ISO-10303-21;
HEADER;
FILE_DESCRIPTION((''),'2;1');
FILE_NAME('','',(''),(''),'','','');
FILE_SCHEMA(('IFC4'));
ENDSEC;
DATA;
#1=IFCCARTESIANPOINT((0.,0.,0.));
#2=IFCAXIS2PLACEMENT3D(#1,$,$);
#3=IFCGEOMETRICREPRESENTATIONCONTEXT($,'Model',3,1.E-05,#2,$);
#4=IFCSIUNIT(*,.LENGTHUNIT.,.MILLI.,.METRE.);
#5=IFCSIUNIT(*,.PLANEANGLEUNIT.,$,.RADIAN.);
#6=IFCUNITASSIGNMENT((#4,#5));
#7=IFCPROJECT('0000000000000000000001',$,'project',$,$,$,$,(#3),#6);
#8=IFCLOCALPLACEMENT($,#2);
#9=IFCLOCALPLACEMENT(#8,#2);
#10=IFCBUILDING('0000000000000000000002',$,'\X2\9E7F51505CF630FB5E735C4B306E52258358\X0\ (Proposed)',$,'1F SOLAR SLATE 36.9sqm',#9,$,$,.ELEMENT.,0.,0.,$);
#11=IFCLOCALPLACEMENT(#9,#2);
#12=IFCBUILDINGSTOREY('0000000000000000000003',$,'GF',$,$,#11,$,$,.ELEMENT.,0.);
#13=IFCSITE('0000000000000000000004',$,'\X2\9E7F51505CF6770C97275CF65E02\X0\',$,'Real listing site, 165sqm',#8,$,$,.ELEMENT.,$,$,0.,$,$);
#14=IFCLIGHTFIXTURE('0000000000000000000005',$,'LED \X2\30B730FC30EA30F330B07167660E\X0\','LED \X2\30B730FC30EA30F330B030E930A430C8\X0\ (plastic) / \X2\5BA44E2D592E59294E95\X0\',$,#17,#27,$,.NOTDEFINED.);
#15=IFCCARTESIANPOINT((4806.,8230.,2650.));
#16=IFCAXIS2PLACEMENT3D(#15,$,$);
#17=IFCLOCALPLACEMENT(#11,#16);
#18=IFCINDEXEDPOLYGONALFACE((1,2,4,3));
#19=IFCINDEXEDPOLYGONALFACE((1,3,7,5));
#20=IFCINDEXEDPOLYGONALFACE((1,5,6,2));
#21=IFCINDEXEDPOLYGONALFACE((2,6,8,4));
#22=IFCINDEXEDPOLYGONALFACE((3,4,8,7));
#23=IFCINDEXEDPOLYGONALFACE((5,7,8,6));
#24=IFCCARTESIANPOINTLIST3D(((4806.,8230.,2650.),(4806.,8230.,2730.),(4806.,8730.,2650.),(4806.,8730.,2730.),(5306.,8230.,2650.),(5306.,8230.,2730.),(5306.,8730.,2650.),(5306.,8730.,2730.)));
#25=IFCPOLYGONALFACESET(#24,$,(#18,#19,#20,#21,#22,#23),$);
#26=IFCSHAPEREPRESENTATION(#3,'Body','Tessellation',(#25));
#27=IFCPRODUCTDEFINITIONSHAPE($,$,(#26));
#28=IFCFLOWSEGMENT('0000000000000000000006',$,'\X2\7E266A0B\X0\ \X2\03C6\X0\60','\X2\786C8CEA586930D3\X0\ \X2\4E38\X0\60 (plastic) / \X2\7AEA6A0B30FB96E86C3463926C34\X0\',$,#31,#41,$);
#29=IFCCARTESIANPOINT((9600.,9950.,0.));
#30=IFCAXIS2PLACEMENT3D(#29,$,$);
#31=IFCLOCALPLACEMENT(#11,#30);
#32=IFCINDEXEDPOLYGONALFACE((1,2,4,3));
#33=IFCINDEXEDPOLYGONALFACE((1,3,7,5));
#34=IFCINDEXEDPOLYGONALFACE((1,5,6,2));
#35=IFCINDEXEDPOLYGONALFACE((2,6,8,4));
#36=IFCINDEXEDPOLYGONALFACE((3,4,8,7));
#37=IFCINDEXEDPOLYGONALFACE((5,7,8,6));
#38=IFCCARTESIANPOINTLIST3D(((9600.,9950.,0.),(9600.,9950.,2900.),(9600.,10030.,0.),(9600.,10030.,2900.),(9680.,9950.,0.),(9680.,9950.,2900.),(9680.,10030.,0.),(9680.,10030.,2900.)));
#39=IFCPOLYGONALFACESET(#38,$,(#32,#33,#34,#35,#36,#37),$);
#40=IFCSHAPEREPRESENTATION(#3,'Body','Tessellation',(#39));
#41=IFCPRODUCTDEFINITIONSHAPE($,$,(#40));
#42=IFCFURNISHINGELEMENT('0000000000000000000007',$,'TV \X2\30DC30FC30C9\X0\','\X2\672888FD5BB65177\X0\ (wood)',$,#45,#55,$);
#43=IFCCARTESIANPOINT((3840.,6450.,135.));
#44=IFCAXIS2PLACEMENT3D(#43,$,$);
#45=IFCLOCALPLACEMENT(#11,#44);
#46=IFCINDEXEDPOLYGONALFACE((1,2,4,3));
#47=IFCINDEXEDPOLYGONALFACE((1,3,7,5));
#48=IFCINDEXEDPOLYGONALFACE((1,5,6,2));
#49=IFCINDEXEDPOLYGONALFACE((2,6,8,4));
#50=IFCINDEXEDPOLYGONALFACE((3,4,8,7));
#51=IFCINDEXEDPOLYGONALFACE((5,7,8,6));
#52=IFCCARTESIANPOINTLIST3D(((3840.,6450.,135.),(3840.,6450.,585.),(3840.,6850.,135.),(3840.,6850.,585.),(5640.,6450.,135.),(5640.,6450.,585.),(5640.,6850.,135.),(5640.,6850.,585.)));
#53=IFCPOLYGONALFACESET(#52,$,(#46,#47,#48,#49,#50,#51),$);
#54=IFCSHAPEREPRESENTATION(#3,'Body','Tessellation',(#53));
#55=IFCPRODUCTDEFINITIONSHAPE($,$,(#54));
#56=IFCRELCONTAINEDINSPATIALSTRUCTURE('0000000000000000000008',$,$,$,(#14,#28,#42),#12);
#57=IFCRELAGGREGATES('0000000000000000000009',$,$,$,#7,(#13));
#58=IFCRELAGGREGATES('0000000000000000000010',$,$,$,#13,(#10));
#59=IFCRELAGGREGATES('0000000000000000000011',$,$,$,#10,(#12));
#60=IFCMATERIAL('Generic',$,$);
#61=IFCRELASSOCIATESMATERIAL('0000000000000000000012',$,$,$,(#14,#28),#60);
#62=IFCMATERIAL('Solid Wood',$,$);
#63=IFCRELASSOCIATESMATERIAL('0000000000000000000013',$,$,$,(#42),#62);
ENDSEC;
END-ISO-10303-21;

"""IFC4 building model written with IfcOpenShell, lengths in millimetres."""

from ifc_helpers import new_model, si_unit, frame, frame_2d, origin, place, context, project, spatial, rectangle, extrude, material, element, save


model = new_model("IFC4")

# Units and contexts
model_context = context("Model", 3, precision=1e-05, world=origin())
ifc_project = project(units=[si_unit("LENGTHUNIT", "METRE", prefix="MILLI"), si_unit("PLANEANGLEUNIT", "RADIAN")], contexts=[model_context])

# Site, building, storey
site_placement = place(None, origin())
site = spatial("IfcSite", under=ifc_project, at=site_placement, Name="鹿児島県霧島市", ObjectType="Real listing site, 165sqm", CompositionType="ELEMENT", RefElevation=0.0)
building_placement = place(site_placement, origin())
building = spatial("IfcBuilding", under=site, at=building_placement, Name="鹿児島・平屋の別荘 (Proposed)", ObjectType="1F SOLAR SLATE 36.9sqm", CompositionType="ELEMENT", ElevationOfRefHeight=0.0, ElevationOfTerrain=0.0)
storey_placement = place(building_placement, origin())
storey = spatial("IfcBuildingStorey", under=building, at=storey_placement, Name="GF", CompositionType="ELEMENT", Elevation=0.0)

# Shared definitions
ifc_material_1 = material(Name="Solid Wood")

# Shared definitions
ifc_material_2 = material(Name="Generic")

# Light fixture
light_fixture_1_placement = place(storey_placement, frame((4806.0, 8230.0, 2650.0)))
element("IfcLightFixture", 1, at=light_fixture_1_placement, inside=storey, material=ifc_material_2, Name="LED シーリング照明", Description="LED シーリングライト (plastic) / 室中央天井", PredefinedType="NOTDEFINED", context=model_context, shape_type="SweptSolid", body=[
    extrude(rectangle(XDim=500.0, YDim=500.0, at=frame_2d((250.0, 250.0))), frame((4806.0, 8230.0, 2650.0)), (0.0, 0.0, 1.0), 80.0),
])

# Flow segment
flow_segment_placement = place(storey_placement, frame((9600.0, 9950.0, 0.0)))
element("IfcFlowSegment", 2, at=flow_segment_placement, inside=storey, material=ifc_material_2, Name="縦樋 φ60", Description="硬質塩ビ 丸60 (plastic) / 竪樋・雨水排水", context=model_context, shape_type="SweptSolid", body=[
    extrude(rectangle(XDim=80.0, YDim=80.0, at=frame_2d((40.0, 40.0))), frame((9600.0, 9950.0, 0.0)), (0.0, 0.0, 1.0), 2900.0),
])

# Furnishing element
furnishing_placement = place(storey_placement, frame((3840.0, 6450.0, 135.0)))
element("IfcFurnishingElement", 3, at=furnishing_placement, inside=storey, material=ifc_material_1, Name="TV ボード", Description="木製家具 (wood)", context=model_context, shape_type="SweptSolid", body=[
    extrude(rectangle(XDim=1800.0, YDim=400.0, at=frame_2d((900.0, 200.0))), frame((3840.0, 6450.0, 135.0)), (0.0, 0.0, 1.0), 450.0),
])

save(model, "model.ifc")
